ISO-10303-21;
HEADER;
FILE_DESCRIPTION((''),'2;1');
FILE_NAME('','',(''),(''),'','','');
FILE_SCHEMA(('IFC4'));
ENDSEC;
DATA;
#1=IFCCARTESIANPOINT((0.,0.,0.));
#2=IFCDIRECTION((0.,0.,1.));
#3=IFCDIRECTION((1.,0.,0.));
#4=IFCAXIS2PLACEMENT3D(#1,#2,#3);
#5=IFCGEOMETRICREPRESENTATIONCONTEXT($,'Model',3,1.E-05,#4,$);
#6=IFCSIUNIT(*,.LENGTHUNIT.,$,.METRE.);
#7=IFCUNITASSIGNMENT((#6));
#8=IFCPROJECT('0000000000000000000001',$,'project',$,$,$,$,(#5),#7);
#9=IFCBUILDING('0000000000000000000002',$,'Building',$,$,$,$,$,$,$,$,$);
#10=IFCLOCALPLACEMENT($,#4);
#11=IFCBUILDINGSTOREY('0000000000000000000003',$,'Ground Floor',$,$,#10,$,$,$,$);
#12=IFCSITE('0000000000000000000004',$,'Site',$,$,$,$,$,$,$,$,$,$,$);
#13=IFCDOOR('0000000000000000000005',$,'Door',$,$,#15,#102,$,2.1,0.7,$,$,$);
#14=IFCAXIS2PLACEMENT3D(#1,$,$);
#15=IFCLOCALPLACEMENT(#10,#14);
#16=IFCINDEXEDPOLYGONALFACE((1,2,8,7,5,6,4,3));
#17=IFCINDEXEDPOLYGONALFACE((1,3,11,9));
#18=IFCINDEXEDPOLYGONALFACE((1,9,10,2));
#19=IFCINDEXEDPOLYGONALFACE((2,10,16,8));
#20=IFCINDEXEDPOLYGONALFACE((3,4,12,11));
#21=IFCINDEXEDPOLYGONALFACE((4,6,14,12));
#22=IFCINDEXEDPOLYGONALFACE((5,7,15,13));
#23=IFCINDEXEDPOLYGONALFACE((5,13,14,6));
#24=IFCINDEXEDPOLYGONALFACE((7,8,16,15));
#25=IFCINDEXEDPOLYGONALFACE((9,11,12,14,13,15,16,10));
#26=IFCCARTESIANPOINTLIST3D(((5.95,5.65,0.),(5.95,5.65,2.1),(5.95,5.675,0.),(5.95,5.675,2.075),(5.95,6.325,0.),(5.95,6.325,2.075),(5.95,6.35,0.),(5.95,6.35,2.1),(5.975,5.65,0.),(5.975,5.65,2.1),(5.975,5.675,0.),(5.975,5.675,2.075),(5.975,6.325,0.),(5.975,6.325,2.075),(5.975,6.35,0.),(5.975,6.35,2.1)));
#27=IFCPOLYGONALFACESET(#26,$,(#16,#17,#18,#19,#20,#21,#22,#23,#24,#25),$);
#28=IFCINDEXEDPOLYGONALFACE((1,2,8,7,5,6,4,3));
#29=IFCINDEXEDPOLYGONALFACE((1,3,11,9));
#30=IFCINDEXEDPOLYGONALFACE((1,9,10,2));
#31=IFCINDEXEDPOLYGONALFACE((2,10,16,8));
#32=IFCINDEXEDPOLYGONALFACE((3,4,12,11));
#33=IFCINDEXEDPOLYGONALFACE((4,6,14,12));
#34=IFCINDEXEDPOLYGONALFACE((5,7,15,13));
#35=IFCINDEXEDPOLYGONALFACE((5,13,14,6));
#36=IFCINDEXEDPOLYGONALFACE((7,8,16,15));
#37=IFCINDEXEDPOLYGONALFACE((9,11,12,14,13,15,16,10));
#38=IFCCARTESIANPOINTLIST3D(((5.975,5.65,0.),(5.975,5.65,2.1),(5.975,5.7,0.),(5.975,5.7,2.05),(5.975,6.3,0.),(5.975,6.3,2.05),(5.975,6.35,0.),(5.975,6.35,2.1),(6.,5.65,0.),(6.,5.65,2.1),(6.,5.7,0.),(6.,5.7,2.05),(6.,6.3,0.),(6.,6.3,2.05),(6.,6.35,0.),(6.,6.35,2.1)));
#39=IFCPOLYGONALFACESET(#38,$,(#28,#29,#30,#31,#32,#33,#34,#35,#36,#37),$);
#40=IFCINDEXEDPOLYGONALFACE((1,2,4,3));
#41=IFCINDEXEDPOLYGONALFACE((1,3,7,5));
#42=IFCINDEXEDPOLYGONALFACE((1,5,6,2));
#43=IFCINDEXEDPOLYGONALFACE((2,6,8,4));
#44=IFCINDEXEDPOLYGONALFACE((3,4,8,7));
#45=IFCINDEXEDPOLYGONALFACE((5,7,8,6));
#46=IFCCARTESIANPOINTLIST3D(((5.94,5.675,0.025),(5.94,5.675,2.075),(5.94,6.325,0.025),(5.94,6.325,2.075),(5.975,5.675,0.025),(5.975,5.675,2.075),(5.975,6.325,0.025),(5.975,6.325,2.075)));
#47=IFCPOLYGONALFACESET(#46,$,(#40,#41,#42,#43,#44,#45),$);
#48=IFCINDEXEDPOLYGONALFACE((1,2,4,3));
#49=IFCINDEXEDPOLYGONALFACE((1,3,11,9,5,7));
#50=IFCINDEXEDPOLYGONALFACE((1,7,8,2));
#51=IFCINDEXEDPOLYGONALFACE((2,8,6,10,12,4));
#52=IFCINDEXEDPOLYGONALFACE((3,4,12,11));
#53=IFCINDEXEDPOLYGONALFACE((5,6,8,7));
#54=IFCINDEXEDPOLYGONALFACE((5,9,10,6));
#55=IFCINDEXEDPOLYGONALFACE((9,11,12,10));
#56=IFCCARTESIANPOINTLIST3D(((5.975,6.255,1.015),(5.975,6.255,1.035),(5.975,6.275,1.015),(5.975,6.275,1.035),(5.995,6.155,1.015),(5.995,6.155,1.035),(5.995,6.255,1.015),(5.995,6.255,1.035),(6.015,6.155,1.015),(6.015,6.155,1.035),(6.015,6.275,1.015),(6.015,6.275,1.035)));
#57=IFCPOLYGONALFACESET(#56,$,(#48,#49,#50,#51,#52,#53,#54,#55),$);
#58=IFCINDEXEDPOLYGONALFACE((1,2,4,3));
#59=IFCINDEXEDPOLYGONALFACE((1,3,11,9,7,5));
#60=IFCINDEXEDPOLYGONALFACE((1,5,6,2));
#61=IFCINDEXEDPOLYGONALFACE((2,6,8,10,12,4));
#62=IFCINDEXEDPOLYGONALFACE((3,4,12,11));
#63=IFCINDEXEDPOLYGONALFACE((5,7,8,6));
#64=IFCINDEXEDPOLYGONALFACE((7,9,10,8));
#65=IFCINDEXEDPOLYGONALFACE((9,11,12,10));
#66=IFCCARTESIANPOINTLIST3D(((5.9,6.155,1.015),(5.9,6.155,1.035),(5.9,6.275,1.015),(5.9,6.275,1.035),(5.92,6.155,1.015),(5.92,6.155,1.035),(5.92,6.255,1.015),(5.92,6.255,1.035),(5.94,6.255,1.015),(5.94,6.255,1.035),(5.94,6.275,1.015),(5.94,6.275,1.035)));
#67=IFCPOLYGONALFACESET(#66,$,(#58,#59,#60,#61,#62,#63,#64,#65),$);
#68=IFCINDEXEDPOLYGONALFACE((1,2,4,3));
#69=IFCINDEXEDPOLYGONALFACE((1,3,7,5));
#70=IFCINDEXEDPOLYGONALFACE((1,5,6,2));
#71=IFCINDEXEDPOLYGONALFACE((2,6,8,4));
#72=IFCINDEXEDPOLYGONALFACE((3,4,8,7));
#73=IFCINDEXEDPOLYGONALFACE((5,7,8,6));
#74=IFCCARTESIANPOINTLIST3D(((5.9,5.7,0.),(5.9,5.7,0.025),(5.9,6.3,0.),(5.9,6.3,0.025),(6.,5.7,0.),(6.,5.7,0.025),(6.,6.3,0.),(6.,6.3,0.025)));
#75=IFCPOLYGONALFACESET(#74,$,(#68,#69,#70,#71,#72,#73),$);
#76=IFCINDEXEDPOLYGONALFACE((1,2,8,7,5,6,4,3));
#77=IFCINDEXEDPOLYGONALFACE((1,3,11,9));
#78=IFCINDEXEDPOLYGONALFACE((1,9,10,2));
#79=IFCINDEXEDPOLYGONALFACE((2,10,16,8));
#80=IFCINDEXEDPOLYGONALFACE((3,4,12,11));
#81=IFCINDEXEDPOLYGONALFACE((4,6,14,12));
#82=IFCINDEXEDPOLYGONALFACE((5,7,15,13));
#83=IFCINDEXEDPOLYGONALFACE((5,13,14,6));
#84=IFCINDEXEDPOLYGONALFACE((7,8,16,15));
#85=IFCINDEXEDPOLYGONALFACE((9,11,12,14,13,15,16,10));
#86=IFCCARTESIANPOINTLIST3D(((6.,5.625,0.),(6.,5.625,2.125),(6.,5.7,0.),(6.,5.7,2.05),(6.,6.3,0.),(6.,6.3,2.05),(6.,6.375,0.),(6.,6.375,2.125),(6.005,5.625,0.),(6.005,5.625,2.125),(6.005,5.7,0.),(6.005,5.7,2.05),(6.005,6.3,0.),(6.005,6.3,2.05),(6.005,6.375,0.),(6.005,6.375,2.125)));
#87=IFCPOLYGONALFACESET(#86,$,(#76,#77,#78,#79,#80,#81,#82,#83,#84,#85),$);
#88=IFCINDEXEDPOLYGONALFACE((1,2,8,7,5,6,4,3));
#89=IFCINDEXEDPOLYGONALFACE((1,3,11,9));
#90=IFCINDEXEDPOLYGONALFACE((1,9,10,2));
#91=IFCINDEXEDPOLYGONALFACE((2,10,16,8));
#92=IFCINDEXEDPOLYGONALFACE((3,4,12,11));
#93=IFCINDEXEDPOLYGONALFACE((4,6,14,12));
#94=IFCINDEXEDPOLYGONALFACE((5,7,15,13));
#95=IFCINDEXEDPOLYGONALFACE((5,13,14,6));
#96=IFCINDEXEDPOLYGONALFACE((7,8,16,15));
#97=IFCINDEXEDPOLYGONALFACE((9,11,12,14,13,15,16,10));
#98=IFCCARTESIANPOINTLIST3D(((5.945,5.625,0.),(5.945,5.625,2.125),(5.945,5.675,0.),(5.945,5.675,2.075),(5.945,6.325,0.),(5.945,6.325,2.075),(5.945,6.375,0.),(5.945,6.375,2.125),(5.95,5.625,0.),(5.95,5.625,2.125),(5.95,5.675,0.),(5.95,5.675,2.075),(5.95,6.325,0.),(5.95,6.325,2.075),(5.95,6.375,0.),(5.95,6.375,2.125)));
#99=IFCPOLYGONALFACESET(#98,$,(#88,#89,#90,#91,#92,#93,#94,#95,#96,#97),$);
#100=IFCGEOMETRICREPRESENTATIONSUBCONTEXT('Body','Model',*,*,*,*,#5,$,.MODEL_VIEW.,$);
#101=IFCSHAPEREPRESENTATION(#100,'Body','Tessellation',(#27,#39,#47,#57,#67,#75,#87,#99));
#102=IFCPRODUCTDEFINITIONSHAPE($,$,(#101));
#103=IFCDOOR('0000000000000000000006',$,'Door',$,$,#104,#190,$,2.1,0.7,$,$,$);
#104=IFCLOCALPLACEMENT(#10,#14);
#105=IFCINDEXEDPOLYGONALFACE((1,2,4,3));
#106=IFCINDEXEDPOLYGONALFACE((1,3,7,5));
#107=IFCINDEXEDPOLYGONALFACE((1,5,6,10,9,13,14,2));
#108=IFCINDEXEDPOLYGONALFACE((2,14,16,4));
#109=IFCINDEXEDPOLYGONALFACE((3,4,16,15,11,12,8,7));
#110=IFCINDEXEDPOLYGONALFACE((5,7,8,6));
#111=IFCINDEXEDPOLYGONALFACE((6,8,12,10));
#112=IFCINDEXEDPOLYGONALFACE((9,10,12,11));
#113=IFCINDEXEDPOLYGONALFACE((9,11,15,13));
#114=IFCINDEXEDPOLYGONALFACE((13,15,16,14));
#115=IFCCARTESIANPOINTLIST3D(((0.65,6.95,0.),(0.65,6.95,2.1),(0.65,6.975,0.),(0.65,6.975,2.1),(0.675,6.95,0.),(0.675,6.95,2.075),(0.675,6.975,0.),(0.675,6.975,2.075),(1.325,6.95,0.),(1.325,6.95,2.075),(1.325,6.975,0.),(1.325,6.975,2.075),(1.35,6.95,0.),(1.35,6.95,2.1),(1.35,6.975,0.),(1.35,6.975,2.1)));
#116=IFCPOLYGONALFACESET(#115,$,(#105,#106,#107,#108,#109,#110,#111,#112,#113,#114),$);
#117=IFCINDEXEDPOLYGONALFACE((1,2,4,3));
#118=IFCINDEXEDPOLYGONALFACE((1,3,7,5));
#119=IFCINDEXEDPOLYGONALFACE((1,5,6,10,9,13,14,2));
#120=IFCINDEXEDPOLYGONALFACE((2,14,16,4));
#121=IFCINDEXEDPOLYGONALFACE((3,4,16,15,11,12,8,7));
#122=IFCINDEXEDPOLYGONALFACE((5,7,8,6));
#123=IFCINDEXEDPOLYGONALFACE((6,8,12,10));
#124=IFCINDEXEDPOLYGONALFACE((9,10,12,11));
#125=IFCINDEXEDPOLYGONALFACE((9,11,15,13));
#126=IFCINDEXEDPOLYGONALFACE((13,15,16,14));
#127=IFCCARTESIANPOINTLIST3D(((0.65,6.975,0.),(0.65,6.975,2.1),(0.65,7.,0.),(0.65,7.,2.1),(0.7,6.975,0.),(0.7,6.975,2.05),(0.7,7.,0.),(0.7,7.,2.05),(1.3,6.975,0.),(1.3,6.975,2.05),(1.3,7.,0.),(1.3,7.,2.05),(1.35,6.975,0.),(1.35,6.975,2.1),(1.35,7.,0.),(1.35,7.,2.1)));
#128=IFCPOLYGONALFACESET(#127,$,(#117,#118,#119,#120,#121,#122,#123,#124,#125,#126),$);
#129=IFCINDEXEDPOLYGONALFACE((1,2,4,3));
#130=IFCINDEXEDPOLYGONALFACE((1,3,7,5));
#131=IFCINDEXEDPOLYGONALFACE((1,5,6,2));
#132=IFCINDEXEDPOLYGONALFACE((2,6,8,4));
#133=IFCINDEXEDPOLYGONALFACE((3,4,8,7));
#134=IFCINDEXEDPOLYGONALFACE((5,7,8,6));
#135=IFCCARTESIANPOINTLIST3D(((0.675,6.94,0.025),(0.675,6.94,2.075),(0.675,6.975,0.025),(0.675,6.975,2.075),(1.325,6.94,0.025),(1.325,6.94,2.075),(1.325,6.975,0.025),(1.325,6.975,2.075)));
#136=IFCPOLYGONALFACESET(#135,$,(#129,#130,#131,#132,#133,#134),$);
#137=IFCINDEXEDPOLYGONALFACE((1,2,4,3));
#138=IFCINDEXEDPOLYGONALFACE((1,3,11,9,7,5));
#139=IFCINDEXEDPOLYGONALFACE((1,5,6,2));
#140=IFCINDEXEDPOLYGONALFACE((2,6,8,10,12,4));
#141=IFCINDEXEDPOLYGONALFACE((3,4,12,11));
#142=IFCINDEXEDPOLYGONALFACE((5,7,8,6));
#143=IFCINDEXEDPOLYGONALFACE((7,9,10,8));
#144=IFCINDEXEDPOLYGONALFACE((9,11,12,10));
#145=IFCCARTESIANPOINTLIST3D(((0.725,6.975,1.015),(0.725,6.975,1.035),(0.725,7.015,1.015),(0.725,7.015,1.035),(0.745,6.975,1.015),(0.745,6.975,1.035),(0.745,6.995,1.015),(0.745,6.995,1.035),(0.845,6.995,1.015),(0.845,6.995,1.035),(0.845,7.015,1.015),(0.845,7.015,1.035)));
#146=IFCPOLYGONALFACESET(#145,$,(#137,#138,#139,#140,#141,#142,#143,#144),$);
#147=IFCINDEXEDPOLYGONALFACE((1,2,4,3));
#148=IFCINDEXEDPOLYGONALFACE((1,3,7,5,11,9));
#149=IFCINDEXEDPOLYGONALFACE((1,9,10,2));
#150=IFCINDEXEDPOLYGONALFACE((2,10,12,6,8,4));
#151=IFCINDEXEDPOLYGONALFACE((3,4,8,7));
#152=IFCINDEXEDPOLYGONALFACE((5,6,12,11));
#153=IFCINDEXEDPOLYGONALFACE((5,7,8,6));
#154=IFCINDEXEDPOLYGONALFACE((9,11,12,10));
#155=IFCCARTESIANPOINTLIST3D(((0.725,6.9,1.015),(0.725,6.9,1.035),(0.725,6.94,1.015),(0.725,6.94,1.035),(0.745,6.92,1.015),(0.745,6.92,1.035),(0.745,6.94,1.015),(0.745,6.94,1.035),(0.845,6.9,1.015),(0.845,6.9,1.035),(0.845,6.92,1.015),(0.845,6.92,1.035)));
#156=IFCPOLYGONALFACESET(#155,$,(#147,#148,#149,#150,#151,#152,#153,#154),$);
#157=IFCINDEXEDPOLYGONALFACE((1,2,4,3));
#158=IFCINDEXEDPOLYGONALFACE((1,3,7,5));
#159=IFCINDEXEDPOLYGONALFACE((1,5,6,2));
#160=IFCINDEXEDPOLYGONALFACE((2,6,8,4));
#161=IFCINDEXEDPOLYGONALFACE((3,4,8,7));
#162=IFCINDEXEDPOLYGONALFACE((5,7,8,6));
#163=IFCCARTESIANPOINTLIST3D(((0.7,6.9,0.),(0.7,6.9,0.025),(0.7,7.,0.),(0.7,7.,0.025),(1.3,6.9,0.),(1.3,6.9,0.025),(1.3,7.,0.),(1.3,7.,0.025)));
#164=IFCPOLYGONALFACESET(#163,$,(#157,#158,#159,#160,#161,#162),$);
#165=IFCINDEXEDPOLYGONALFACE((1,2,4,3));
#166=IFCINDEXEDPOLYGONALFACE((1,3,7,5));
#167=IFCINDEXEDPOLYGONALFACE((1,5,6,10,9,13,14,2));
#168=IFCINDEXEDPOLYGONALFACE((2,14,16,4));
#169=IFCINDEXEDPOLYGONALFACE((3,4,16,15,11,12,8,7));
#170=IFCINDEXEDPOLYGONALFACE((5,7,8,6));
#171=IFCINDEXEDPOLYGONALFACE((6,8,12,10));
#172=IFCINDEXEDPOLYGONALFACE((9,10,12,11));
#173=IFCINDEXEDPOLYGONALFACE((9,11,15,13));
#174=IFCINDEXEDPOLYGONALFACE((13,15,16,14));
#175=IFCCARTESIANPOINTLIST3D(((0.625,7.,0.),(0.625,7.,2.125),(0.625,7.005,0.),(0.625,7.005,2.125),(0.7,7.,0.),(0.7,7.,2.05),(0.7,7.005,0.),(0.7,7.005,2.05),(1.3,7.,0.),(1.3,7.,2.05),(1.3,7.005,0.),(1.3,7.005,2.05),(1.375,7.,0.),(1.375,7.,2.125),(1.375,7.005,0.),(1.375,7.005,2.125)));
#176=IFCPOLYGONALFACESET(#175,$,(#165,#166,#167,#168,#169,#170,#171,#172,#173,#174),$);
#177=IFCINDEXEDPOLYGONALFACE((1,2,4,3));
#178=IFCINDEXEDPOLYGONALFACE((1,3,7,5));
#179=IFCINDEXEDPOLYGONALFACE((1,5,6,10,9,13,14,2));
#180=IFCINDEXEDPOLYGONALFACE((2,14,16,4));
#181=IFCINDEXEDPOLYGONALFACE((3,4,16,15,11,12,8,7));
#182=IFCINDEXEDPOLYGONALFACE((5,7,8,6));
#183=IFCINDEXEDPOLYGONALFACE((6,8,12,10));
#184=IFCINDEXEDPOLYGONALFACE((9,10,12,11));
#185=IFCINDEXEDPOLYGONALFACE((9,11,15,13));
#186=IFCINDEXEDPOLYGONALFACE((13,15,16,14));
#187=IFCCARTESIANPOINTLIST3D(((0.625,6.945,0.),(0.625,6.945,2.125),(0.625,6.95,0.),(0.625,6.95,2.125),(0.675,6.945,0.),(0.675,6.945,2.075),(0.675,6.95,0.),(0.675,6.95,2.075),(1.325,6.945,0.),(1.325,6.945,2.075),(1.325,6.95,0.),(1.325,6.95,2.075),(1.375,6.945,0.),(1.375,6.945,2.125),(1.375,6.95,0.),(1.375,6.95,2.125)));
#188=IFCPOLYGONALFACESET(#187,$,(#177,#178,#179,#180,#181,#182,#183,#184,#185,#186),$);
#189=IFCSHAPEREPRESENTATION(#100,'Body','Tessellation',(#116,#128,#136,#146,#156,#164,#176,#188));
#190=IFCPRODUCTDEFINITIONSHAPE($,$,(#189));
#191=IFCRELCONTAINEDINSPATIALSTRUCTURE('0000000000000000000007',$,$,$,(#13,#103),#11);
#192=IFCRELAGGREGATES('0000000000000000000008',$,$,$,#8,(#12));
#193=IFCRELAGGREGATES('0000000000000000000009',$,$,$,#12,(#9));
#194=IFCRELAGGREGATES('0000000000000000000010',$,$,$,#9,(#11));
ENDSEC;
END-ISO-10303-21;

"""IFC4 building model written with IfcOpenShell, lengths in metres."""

from ifc_helpers import new_model, si_unit, frame, origin_with_axes, place, context, subcontext, project, spatial, line, indexed_curve, outline, extrude, element, save


model = new_model("IFC4")

# Units and contexts
model_context = context("Model", 3, precision=1e-05, world=origin_with_axes())
body_context = subcontext(model_context, "Body", "Model", "MODEL_VIEW")
ifc_project = project(units=[si_unit("LENGTHUNIT", "METRE")], contexts=[model_context])

# Site, building, storey
site = spatial("IfcSite", under=ifc_project, Name="Site")
building = spatial("IfcBuilding", under=site, Name="Building")
storey_placement = place(None, origin_with_axes())
storey = spatial("IfcBuildingStorey", under=building, at=storey_placement, Name="Ground Floor")

# Doors
door_1_placement = place(storey_placement, frame((6.0, 5.65, 0.0), z_axis=(0.0, 0.0, 1.0), x_axis=(0.0, 1.0, 0.0)))
element("IfcDoor", 1, at=door_1_placement, inside=storey, Name="Door", OverallHeight=2.1, OverallWidth=0.7, context=body_context, shape_type="SweptSolid", body=[
    extrude(outline(indexed_curve([(0.0, 0.0), (0.0, 2.1), (0.7, 2.1), (0.7, 0.0), (0.675, 0.0), (0.675, 2.075), (0.025, 2.075), (0.025, 0.0)], segments=[line(1, 2, 3, 4, 5, 6, 7, 8, 1)])), frame((0.0, 0.025, 0.0), z_axis=(0.0, -1.0, 0.0), x_axis=(1.0, 0.0, 0.0)), (0.0, 0.0, -1.0), 0.025),
    extrude(outline(indexed_curve([(0.0, 0.0), (0.0, 2.1), (0.7, 2.1), (0.7, 0.0), (0.65, 0.0), (0.65, 2.05), (0.05, 2.05), (0.05, 0.0)], segments=[line(1, 2, 3, 4, 5, 6, 7, 8, 1)])), frame((0.0, 0.0, 0.0), z_axis=(0.0, -1.0, 0.0), x_axis=(1.0, 0.0, 0.0)), (0.0, 0.0, -1.0), 0.025),
    extrude(outline(indexed_curve([(0.0, 0.0), (0.65, 0.0), (0.65, 0.035), (0.0, 0.035)], segments=[line(1, 2, 3, 4, 1)])), frame((0.025, 0.025, 0.025), z_axis=(0.0, 0.0, 1.0), x_axis=(1.0, 0.0, 0.0)), (0.0, 0.0, 1.0), 2.05),
    extrude(outline(indexed_curve([(0.0, 0.0), (0.0, -0.04), (-0.12, -0.04), (-0.12, -0.02), (-0.02, -0.02), (-0.02, 0.0)], segments=[line(1, 2, 3, 4, 5, 6, 1)])), frame((0.625, 0.025, 1.015), z_axis=(0.0, 0.0, 1.0), x_axis=(1.0, 0.0, 0.0)), (0.0, 0.0, 1.0), 0.02),
    extrude(outline(indexed_curve([(0.0, 0.0), (0.0, 0.04), (-0.12, 0.04), (-0.12, 0.02), (-0.02, 0.02), (-0.02, 0.0)], segments=[line(1, 2, 3, 4, 5, 6, 1)])), frame((0.625, 0.06, 1.015), z_axis=(0.0, 0.0, 1.0), x_axis=(1.0, 0.0, 0.0)), (0.0, 0.0, 1.0), 0.02),
    extrude(outline(indexed_curve([(0.0, 0.0), (0.6, 0.0), (0.6, 0.1), (0.0, 0.1)], segments=[line(1, 2, 3, 4, 1)])), frame((0.05, 0.0, 0.0), z_axis=(0.0, 0.0, 1.0), x_axis=(1.0, 0.0, 0.0)), (0.0, 0.0, 1.0), 0.025),
    extrude(outline(indexed_curve([(0.0, 0.0), (0.0, 2.125), (0.75, 2.125), (0.75, 0.0), (0.675, 0.0), (0.675, 2.05), (0.075, 2.05), (0.075, 0.0)], segments=[line(1, 2, 3, 4, 5, 6, 7, 8, 1)])), frame((-0.025, -0.005, 0.0), z_axis=(0.0, -1.0, 0.0), x_axis=(1.0, 0.0, 0.0)), (0.0, 0.0, -1.0), 0.005),
    extrude(outline(indexed_curve([(0.0, 0.0), (0.0, 2.125), (0.75, 2.125), (0.75, 0.0), (0.7, 0.0), (0.7, 2.075), (0.05, 2.075), (0.05, 0.0)], segments=[line(1, 2, 3, 4, 5, 6, 7, 8, 1)])), frame((-0.025, 0.05, 0.0), z_axis=(0.0, -1.0, 0.0), x_axis=(1.0, 0.0, 0.0)), (0.0, 0.0, -1.0), 0.005),
])
door_2_placement = place(storey_placement, frame((1.35, 7.0, 0.0), z_axis=(0.0, 0.0, 1.0), x_axis=(-1.0, 0.0, 0.0)))
element("IfcDoor", 2, at=door_2_placement, inside=storey, Name="Door", OverallHeight=2.1, OverallWidth=0.7, context=body_context, shape_type="SweptSolid", body=[
    extrude(outline(indexed_curve([(0.0, 0.0), (0.0, 2.1), (0.7, 2.1), (0.7, 0.0), (0.675, 0.0), (0.675, 2.075), (0.025, 2.075), (0.025, 0.0)], segments=[line(1, 2, 3, 4, 5, 6, 7, 8, 1)])), frame((0.0, 0.025, 0.0), z_axis=(0.0, -1.0, 0.0), x_axis=(1.0, 0.0, 0.0)), (0.0, 0.0, -1.0), 0.025),
    extrude(outline(indexed_curve([(0.0, 0.0), (0.0, 2.1), (0.7, 2.1), (0.7, 0.0), (0.65, 0.0), (0.65, 2.05), (0.05, 2.05), (0.05, 0.0)], segments=[line(1, 2, 3, 4, 5, 6, 7, 8, 1)])), frame((0.0, 0.0, 0.0), z_axis=(0.0, -1.0, 0.0), x_axis=(1.0, 0.0, 0.0)), (0.0, 0.0, -1.0), 0.025),
    extrude(outline(indexed_curve([(0.0, 0.0), (0.65, 0.0), (0.65, 0.035), (0.0, 0.035)], segments=[line(1, 2, 3, 4, 1)])), frame((0.025, 0.025, 0.025), z_axis=(0.0, 0.0, 1.0), x_axis=(1.0, 0.0, 0.0)), (0.0, 0.0, 1.0), 2.05),
    extrude(outline(indexed_curve([(0.0, 0.0), (0.0, -0.04), (-0.12, -0.04), (-0.12, -0.02), (-0.02, -0.02), (-0.02, 0.0)], segments=[line(1, 2, 3, 4, 5, 6, 1)])), frame((0.625, 0.025, 1.015), z_axis=(0.0, 0.0, 1.0), x_axis=(1.0, 0.0, 0.0)), (0.0, 0.0, 1.0), 0.02),
    extrude(outline(indexed_curve([(0.0, 0.0), (0.0, 0.04), (-0.12, 0.04), (-0.12, 0.02), (-0.02, 0.02), (-0.02, 0.0)], segments=[line(1, 2, 3, 4, 5, 6, 1)])), frame((0.625, 0.06, 1.015), z_axis=(0.0, 0.0, 1.0), x_axis=(1.0, 0.0, 0.0)), (0.0, 0.0, 1.0), 0.02),
    extrude(outline(indexed_curve([(0.0, 0.0), (0.6, 0.0), (0.6, 0.1), (0.0, 0.1)], segments=[line(1, 2, 3, 4, 1)])), frame((0.05, 0.0, 0.0), z_axis=(0.0, 0.0, 1.0), x_axis=(1.0, 0.0, 0.0)), (0.0, 0.0, 1.0), 0.025),
    extrude(outline(indexed_curve([(0.0, 0.0), (0.0, 2.125), (0.75, 2.125), (0.75, 0.0), (0.675, 0.0), (0.675, 2.05), (0.075, 2.05), (0.075, 0.0)], segments=[line(1, 2, 3, 4, 5, 6, 7, 8, 1)])), frame((-0.025, -0.005, 0.0), z_axis=(0.0, -1.0, 0.0), x_axis=(1.0, 0.0, 0.0)), (0.0, 0.0, -1.0), 0.005),
    extrude(outline(indexed_curve([(0.0, 0.0), (0.0, 2.125), (0.75, 2.125), (0.75, 0.0), (0.7, 0.0), (0.7, 2.075), (0.05, 2.075), (0.05, 0.0)], segments=[line(1, 2, 3, 4, 5, 6, 7, 8, 1)])), frame((-0.025, 0.05, 0.0), z_axis=(0.0, -1.0, 0.0), x_axis=(1.0, 0.0, 0.0)), (0.0, 0.0, -1.0), 0.005),
])

save(model, "model.ifc")
